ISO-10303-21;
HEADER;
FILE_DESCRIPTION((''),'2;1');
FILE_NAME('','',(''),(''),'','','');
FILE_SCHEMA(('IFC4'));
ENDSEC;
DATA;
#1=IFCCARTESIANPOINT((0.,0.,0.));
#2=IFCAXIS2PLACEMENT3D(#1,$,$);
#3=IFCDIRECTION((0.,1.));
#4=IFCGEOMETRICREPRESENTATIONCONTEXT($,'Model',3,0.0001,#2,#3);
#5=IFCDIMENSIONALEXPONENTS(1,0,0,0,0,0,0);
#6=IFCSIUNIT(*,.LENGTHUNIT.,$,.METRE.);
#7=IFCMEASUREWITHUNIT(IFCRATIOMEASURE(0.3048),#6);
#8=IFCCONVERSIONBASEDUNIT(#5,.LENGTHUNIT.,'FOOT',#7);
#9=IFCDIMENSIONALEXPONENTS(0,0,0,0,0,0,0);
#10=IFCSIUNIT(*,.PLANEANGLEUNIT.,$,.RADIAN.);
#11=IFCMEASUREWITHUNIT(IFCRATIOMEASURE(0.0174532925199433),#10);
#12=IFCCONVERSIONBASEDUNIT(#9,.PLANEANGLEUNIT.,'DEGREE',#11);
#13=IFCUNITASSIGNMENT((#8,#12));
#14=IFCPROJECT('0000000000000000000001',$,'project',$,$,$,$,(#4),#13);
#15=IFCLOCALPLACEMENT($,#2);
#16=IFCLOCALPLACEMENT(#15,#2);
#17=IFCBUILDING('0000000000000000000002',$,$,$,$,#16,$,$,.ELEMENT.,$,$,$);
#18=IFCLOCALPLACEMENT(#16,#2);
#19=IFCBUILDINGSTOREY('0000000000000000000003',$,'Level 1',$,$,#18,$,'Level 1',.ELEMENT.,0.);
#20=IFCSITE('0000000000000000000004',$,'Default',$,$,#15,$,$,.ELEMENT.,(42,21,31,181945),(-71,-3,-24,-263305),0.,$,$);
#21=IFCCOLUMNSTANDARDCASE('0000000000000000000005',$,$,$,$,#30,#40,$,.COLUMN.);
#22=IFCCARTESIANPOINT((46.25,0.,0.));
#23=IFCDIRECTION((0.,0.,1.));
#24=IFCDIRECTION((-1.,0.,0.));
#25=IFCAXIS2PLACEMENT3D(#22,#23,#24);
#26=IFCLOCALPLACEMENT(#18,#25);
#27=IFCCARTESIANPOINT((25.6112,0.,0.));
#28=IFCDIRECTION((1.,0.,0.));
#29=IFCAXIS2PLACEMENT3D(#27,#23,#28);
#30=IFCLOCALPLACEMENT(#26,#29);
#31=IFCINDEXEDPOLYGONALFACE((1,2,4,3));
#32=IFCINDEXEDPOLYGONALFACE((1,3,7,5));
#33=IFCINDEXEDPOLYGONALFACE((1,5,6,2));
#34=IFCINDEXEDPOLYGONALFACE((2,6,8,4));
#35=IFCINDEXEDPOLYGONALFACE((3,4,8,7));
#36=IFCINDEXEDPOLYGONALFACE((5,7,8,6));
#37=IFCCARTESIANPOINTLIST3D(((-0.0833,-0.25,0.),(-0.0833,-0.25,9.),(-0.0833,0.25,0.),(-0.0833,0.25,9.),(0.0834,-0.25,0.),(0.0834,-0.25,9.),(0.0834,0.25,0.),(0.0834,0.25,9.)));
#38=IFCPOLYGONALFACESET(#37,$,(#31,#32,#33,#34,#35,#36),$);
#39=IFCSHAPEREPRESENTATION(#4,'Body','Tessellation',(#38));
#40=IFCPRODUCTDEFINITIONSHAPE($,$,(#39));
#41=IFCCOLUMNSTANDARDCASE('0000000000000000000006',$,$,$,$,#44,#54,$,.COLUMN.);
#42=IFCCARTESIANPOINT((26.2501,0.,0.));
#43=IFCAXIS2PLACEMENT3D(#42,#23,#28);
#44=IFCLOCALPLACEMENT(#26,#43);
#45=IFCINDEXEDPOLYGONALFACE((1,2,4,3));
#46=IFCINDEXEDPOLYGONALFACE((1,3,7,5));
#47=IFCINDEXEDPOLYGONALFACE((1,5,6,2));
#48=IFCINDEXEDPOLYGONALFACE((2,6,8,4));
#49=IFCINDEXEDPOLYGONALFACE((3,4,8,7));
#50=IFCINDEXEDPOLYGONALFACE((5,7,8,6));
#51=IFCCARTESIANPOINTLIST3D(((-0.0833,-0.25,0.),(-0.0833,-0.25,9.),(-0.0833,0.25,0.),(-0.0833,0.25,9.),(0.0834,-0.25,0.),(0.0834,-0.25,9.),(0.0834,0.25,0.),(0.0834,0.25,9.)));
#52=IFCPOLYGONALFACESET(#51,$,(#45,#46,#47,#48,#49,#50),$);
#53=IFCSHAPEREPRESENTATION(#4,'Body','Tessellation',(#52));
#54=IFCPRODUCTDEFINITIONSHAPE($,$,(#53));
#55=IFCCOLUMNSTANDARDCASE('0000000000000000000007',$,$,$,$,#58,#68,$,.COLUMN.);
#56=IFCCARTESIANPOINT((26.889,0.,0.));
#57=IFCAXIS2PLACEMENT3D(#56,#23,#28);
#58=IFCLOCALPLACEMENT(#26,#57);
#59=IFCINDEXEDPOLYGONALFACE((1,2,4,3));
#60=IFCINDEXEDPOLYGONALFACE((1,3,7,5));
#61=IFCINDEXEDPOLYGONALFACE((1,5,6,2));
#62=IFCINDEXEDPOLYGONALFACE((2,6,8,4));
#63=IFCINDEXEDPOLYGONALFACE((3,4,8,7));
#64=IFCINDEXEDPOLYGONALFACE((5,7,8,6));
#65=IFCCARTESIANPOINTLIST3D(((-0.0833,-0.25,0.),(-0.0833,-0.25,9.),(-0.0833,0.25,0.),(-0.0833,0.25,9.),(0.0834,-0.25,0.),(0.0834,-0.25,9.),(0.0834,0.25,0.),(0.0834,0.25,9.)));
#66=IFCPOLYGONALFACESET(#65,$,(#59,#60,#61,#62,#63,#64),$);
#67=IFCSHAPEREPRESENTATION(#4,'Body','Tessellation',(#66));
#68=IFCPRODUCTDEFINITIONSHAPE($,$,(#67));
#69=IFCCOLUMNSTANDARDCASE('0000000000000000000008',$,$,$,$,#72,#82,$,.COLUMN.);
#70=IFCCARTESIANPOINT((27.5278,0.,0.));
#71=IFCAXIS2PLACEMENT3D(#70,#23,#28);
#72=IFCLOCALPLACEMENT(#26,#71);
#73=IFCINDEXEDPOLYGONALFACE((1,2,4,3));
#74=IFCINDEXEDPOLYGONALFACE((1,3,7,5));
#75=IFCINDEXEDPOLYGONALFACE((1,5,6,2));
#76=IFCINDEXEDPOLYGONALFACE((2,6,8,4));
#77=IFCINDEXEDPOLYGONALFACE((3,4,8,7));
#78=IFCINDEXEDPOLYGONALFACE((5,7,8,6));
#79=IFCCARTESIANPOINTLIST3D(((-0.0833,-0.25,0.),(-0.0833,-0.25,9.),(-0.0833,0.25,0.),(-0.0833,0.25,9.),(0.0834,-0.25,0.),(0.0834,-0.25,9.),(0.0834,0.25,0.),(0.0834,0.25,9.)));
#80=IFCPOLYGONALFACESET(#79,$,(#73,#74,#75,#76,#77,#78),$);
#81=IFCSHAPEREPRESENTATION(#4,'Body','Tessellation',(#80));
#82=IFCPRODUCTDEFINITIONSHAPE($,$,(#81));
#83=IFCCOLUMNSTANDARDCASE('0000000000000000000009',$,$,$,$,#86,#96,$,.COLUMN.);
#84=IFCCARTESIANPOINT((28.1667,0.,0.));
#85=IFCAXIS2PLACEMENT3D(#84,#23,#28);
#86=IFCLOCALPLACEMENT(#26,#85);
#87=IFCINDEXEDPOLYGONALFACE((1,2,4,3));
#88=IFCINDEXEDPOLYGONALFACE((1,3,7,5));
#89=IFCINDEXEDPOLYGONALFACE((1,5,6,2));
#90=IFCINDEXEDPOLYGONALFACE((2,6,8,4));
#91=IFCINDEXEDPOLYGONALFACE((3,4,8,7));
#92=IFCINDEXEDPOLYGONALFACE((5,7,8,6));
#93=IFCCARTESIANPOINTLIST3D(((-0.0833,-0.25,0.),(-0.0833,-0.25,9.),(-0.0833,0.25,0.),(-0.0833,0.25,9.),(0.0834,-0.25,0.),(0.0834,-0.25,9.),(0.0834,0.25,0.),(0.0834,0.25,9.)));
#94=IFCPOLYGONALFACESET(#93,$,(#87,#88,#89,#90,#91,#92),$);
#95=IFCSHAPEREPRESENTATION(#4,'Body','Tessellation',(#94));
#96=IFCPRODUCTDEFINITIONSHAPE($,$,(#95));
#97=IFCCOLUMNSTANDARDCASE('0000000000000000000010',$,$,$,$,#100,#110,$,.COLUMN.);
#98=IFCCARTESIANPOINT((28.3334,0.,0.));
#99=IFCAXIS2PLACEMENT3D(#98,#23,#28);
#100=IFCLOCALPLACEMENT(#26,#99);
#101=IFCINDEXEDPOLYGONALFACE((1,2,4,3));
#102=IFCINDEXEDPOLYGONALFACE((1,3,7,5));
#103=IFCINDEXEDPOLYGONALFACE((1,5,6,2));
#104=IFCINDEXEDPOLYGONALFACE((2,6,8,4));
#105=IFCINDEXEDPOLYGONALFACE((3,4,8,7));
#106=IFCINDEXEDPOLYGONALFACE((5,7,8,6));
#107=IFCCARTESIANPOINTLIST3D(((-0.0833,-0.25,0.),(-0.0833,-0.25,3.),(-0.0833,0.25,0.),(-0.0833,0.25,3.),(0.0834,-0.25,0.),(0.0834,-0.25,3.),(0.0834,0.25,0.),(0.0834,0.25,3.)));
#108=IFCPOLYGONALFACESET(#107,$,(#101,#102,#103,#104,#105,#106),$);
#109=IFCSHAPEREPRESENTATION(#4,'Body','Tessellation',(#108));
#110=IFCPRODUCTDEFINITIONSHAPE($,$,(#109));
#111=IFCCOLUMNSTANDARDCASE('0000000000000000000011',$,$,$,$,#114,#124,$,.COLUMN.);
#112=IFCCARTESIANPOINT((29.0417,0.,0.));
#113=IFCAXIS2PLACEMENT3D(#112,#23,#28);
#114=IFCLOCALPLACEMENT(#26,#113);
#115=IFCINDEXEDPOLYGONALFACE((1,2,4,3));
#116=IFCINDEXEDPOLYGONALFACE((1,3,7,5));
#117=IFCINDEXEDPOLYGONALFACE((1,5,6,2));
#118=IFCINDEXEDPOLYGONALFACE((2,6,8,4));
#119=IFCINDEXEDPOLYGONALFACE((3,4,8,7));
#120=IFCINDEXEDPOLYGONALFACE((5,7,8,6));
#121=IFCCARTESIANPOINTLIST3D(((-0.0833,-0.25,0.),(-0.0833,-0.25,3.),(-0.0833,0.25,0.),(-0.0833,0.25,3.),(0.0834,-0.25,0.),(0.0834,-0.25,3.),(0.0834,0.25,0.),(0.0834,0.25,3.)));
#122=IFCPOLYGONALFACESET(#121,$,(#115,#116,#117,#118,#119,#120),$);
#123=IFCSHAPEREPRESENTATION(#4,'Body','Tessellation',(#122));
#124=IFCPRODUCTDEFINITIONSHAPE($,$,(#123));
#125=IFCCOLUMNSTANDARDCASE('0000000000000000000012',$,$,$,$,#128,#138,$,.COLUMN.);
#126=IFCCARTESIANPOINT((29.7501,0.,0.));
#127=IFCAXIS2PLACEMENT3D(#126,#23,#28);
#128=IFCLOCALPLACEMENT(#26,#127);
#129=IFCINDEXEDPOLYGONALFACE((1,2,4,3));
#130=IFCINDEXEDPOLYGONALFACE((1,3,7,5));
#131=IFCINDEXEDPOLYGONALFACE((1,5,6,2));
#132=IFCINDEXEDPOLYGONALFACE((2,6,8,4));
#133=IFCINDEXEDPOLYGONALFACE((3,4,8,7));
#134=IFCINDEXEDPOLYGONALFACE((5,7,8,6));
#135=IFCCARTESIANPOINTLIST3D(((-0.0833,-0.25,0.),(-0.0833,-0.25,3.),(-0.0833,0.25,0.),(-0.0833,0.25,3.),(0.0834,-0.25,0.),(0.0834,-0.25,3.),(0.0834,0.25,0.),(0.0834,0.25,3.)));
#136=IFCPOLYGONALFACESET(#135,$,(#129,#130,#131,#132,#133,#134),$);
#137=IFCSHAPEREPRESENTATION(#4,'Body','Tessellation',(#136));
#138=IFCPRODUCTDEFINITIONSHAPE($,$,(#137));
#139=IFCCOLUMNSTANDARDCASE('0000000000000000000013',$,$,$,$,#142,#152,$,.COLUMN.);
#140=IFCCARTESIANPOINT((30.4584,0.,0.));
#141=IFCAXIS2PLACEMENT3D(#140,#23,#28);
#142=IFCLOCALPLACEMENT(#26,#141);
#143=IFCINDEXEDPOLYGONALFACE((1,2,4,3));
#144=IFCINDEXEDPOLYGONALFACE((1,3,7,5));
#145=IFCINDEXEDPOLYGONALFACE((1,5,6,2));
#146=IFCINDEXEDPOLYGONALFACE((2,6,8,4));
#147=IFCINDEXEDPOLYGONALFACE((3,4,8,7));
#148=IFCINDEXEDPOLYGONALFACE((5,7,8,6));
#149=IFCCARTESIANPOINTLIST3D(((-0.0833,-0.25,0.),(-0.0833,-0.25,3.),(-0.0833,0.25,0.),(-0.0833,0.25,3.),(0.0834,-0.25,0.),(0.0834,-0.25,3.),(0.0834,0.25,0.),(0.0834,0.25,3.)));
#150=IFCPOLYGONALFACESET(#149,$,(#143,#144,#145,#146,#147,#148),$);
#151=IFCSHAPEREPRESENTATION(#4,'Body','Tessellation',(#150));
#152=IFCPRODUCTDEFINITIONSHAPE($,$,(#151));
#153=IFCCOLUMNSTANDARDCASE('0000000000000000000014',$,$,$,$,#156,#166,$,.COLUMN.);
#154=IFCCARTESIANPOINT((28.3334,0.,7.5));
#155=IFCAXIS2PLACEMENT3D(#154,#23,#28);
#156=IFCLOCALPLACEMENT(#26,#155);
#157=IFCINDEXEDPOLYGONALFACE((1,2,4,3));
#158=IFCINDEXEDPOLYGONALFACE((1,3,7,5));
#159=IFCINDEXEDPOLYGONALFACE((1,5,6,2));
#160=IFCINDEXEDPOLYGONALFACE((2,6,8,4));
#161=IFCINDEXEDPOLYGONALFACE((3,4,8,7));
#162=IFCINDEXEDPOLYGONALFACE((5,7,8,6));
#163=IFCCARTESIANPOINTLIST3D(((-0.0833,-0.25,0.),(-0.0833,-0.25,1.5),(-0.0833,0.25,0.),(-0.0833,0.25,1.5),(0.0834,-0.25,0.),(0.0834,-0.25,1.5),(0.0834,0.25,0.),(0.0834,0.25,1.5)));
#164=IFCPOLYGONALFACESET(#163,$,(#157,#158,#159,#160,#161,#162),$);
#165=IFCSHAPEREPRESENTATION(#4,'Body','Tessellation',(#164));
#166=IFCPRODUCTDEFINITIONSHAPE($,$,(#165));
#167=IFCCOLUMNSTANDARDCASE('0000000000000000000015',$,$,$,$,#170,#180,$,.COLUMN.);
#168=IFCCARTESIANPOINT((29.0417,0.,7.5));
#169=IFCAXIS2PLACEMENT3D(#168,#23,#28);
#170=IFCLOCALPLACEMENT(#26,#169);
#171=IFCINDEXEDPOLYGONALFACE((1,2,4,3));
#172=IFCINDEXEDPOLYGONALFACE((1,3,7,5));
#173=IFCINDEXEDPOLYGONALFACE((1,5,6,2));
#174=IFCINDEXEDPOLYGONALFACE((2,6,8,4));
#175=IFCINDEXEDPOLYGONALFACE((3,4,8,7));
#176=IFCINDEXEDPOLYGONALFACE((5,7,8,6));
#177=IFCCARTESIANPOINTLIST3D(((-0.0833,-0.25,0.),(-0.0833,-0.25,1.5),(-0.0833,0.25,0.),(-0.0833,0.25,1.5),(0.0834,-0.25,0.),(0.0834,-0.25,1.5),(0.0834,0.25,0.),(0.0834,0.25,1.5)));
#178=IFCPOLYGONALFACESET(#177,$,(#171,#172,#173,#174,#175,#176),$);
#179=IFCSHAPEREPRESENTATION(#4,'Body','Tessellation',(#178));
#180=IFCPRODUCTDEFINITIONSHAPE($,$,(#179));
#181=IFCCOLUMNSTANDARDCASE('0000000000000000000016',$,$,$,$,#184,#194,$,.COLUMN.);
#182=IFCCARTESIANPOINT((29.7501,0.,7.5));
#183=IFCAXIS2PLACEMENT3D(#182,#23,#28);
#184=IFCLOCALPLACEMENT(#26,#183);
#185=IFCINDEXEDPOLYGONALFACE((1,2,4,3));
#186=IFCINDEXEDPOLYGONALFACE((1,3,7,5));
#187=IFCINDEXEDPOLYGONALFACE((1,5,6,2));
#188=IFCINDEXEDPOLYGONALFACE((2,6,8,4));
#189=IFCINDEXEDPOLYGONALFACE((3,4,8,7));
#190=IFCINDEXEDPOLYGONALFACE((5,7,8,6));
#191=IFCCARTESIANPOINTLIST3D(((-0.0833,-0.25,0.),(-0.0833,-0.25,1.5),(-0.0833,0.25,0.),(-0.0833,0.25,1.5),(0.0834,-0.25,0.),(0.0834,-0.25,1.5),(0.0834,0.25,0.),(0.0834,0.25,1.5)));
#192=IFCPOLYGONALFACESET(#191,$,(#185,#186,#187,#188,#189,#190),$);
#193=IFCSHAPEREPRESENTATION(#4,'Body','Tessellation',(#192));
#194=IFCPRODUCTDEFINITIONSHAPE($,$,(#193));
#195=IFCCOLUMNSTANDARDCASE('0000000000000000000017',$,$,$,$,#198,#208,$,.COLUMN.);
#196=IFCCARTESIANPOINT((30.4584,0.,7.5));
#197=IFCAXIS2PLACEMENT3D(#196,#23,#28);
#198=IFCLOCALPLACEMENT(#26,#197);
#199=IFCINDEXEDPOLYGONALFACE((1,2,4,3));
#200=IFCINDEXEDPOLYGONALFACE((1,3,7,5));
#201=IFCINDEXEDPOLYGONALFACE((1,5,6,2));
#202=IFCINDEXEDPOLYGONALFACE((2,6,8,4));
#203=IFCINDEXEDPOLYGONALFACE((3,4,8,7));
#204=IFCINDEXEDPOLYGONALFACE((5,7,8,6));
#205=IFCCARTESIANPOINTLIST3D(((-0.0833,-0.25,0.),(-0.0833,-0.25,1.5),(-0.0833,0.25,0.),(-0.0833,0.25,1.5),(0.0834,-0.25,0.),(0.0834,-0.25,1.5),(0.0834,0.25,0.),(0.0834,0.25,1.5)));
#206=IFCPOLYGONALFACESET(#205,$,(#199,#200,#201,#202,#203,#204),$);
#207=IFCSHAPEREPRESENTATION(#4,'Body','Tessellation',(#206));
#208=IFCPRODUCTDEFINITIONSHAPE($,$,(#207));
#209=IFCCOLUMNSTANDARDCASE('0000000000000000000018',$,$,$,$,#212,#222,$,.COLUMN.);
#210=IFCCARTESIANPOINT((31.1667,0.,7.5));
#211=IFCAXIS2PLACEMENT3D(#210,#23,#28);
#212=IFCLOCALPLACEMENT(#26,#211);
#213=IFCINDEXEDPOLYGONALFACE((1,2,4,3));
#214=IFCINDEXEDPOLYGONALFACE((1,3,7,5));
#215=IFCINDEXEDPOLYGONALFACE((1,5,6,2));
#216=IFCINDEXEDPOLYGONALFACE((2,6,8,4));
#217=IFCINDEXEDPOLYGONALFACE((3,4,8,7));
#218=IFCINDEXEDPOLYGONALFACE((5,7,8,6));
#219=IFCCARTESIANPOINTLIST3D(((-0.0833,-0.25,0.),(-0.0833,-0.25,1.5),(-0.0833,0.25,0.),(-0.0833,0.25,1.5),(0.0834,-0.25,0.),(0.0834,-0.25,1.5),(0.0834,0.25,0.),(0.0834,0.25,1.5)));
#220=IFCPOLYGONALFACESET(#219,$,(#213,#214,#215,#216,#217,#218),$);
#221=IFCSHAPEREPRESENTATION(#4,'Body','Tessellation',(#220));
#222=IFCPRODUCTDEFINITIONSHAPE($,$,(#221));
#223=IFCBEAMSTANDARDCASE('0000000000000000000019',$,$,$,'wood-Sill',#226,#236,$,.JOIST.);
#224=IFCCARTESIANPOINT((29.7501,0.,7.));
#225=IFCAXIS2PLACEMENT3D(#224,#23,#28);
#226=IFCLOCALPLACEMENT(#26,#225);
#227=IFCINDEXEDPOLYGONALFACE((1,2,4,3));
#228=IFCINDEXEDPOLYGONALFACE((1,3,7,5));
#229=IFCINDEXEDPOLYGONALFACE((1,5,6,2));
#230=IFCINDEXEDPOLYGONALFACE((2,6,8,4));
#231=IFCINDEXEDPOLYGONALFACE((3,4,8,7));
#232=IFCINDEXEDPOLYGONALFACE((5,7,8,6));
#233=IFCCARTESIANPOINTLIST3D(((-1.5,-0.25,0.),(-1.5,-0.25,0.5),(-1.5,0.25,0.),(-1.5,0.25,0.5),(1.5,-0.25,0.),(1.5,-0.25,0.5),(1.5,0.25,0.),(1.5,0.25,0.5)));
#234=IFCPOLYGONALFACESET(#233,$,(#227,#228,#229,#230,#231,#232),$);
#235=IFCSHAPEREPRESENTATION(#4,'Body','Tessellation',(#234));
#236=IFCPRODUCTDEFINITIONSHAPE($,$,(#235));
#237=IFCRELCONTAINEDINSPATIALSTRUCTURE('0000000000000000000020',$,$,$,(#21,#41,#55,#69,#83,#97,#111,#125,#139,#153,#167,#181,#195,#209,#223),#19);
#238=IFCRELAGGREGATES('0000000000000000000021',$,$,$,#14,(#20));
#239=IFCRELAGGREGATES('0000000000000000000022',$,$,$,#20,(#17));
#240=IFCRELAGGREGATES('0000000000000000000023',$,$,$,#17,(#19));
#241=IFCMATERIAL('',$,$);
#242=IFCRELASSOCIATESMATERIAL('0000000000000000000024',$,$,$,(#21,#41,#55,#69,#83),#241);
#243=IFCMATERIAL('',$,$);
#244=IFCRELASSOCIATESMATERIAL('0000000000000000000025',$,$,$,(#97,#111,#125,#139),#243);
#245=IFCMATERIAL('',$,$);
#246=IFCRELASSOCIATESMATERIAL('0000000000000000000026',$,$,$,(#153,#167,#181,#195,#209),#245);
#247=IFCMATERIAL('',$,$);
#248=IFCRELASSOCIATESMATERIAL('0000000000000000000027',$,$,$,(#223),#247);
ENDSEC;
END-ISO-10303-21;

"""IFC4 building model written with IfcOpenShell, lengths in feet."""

from ifc_helpers import new_model, entity, si_unit, converted_unit, direction, frame, origin, place, context, project, spatial, rectangle, extrude, material, element, save


model = new_model("IFC4")

# Units and contexts
model_context = context("Model", 3, precision=0.0001, world=origin(), true_north=direction((0.0, 1.0)))
ifc_project = project(units=[converted_unit("LENGTHUNIT", "FOOT", entity("IfcRatioMeasure", 0.3048), si_unit("LENGTHUNIT", "METRE"), dimensions=[1, 0, 0, 0, 0, 0, 0]), converted_unit("PLANEANGLEUNIT", "DEGREE", entity("IfcRatioMeasure", 0.0174532925199433), si_unit("PLANEANGLEUNIT", "RADIAN"), dimensions=[0, 0, 0, 0, 0, 0, 0])], contexts=[model_context])

# Site, building, storey
site_placement = place(None, origin())
site = spatial("IfcSite", under=ifc_project, at=site_placement, Name="Default", CompositionType="ELEMENT", RefLatitude=(42, 21, 31, 181945), RefLongitude=(-71, -3, -24, -263305), RefElevation=0.0)
building_placement = place(site_placement, origin())
building = spatial("IfcBuilding", under=site, at=building_placement, CompositionType="ELEMENT")
storey_placement = place(building_placement, origin())
storey = spatial("IfcBuildingStorey", under=building, at=storey_placement, Name="Level 1", LongName="Level 1", CompositionType="ELEMENT", Elevation=0.0)

# Columns
ifc_material_1 = material(Name="")
placement = place(storey_placement, frame((46.25, 0.0, 0.0), z_axis=(0.0, 0.0, 1.0), x_axis=(-1.0, 0.0, 0.0)))
for number, where, z_axis, x_axis in (
    (1, (25.6112, 0.0, 0.0), (0.0, 0.0, 1.0), (1.0, 0.0, 0.0)),
    (2, (26.2501, 0.0, 0.0), (0.0, 0.0, 1.0), (1.0, 0.0, 0.0)),
    (3, (26.889, 0.0, 0.0), (0.0, 0.0, 1.0), (1.0, 0.0, 0.0)),
    (4, (27.5278, 0.0, 0.0), (0.0, 0.0, 1.0), (1.0, 0.0, 0.0)),
    (5, (28.1667, 0.0, 0.0), (0.0, 0.0, 1.0), (1.0, 0.0, 0.0)),
):
    element("IfcColumnStandardCase", number, at=place(placement, frame(where, z_axis=z_axis, x_axis=x_axis)), inside=storey, material=ifc_material_1, PredefinedType="COLUMN", context=model_context, shape_type="SweptSolid", body=[
        extrude(rectangle(XDim=0.1667, YDim=0.5), origin(), (0.0, 0.0, 1.0), 9.0),
    ])
ifc_material_2 = material(Name="")
for number, where, z_axis, x_axis in (
    (6, (28.3334, 0.0, 0.0), (0.0, 0.0, 1.0), (1.0, 0.0, 0.0)),
    (7, (29.0417, 0.0, 0.0), (0.0, 0.0, 1.0), (1.0, 0.0, 0.0)),
    (8, (29.7501, 0.0, 0.0), (0.0, 0.0, 1.0), (1.0, 0.0, 0.0)),
    (9, (30.4584, 0.0, 0.0), (0.0, 0.0, 1.0), (1.0, 0.0, 0.0)),
):
    element("IfcColumnStandardCase", number, at=place(placement, frame(where, z_axis=z_axis, x_axis=x_axis)), inside=storey, material=ifc_material_2, PredefinedType="COLUMN", context=model_context, shape_type="SweptSolid", body=[
        extrude(rectangle(XDim=0.1667, YDim=0.5), origin(), (0.0, 0.0, 1.0), 3.0),
    ])
ifc_material_3 = material(Name="")
for number, where, z_axis, x_axis in (
    (10, (28.3334, 0.0, 7.5), (0.0, 0.0, 1.0), (1.0, 0.0, 0.0)),
    (11, (29.0417, 0.0, 7.5), (0.0, 0.0, 1.0), (1.0, 0.0, 0.0)),
    (12, (29.7501, 0.0, 7.5), (0.0, 0.0, 1.0), (1.0, 0.0, 0.0)),
    (13, (30.4584, 0.0, 7.5), (0.0, 0.0, 1.0), (1.0, 0.0, 0.0)),
    (14, (31.1667, 0.0, 7.5), (0.0, 0.0, 1.0), (1.0, 0.0, 0.0)),
):
    element("IfcColumnStandardCase", number, at=place(placement, frame(where, z_axis=z_axis, x_axis=x_axis)), inside=storey, material=ifc_material_3, PredefinedType="COLUMN", context=model_context, shape_type="SweptSolid", body=[
        extrude(rectangle(XDim=0.1667, YDim=0.5), origin(), (0.0, 0.0, 1.0), 1.5),
    ])

# Beam
ifc_material_4 = material(Name="")
for number, where, z_axis, x_axis in (
    (15, (29.7501, 0.0, 7.0), (0.0, 0.0, 1.0), (1.0, 0.0, 0.0)),
):
    element("IfcBeamStandardCase", number, at=place(placement, frame(where, z_axis=z_axis, x_axis=x_axis)), inside=storey, material=ifc_material_4, ObjectType="wood-Sill", PredefinedType="JOIST", context=model_context, shape_type="SweptSolid", body=[
        extrude(rectangle(XDim=3.0, YDim=0.5), origin(), (0.0, 0.0, 1.0), 0.5),
    ])

save(model, "model.ifc")
